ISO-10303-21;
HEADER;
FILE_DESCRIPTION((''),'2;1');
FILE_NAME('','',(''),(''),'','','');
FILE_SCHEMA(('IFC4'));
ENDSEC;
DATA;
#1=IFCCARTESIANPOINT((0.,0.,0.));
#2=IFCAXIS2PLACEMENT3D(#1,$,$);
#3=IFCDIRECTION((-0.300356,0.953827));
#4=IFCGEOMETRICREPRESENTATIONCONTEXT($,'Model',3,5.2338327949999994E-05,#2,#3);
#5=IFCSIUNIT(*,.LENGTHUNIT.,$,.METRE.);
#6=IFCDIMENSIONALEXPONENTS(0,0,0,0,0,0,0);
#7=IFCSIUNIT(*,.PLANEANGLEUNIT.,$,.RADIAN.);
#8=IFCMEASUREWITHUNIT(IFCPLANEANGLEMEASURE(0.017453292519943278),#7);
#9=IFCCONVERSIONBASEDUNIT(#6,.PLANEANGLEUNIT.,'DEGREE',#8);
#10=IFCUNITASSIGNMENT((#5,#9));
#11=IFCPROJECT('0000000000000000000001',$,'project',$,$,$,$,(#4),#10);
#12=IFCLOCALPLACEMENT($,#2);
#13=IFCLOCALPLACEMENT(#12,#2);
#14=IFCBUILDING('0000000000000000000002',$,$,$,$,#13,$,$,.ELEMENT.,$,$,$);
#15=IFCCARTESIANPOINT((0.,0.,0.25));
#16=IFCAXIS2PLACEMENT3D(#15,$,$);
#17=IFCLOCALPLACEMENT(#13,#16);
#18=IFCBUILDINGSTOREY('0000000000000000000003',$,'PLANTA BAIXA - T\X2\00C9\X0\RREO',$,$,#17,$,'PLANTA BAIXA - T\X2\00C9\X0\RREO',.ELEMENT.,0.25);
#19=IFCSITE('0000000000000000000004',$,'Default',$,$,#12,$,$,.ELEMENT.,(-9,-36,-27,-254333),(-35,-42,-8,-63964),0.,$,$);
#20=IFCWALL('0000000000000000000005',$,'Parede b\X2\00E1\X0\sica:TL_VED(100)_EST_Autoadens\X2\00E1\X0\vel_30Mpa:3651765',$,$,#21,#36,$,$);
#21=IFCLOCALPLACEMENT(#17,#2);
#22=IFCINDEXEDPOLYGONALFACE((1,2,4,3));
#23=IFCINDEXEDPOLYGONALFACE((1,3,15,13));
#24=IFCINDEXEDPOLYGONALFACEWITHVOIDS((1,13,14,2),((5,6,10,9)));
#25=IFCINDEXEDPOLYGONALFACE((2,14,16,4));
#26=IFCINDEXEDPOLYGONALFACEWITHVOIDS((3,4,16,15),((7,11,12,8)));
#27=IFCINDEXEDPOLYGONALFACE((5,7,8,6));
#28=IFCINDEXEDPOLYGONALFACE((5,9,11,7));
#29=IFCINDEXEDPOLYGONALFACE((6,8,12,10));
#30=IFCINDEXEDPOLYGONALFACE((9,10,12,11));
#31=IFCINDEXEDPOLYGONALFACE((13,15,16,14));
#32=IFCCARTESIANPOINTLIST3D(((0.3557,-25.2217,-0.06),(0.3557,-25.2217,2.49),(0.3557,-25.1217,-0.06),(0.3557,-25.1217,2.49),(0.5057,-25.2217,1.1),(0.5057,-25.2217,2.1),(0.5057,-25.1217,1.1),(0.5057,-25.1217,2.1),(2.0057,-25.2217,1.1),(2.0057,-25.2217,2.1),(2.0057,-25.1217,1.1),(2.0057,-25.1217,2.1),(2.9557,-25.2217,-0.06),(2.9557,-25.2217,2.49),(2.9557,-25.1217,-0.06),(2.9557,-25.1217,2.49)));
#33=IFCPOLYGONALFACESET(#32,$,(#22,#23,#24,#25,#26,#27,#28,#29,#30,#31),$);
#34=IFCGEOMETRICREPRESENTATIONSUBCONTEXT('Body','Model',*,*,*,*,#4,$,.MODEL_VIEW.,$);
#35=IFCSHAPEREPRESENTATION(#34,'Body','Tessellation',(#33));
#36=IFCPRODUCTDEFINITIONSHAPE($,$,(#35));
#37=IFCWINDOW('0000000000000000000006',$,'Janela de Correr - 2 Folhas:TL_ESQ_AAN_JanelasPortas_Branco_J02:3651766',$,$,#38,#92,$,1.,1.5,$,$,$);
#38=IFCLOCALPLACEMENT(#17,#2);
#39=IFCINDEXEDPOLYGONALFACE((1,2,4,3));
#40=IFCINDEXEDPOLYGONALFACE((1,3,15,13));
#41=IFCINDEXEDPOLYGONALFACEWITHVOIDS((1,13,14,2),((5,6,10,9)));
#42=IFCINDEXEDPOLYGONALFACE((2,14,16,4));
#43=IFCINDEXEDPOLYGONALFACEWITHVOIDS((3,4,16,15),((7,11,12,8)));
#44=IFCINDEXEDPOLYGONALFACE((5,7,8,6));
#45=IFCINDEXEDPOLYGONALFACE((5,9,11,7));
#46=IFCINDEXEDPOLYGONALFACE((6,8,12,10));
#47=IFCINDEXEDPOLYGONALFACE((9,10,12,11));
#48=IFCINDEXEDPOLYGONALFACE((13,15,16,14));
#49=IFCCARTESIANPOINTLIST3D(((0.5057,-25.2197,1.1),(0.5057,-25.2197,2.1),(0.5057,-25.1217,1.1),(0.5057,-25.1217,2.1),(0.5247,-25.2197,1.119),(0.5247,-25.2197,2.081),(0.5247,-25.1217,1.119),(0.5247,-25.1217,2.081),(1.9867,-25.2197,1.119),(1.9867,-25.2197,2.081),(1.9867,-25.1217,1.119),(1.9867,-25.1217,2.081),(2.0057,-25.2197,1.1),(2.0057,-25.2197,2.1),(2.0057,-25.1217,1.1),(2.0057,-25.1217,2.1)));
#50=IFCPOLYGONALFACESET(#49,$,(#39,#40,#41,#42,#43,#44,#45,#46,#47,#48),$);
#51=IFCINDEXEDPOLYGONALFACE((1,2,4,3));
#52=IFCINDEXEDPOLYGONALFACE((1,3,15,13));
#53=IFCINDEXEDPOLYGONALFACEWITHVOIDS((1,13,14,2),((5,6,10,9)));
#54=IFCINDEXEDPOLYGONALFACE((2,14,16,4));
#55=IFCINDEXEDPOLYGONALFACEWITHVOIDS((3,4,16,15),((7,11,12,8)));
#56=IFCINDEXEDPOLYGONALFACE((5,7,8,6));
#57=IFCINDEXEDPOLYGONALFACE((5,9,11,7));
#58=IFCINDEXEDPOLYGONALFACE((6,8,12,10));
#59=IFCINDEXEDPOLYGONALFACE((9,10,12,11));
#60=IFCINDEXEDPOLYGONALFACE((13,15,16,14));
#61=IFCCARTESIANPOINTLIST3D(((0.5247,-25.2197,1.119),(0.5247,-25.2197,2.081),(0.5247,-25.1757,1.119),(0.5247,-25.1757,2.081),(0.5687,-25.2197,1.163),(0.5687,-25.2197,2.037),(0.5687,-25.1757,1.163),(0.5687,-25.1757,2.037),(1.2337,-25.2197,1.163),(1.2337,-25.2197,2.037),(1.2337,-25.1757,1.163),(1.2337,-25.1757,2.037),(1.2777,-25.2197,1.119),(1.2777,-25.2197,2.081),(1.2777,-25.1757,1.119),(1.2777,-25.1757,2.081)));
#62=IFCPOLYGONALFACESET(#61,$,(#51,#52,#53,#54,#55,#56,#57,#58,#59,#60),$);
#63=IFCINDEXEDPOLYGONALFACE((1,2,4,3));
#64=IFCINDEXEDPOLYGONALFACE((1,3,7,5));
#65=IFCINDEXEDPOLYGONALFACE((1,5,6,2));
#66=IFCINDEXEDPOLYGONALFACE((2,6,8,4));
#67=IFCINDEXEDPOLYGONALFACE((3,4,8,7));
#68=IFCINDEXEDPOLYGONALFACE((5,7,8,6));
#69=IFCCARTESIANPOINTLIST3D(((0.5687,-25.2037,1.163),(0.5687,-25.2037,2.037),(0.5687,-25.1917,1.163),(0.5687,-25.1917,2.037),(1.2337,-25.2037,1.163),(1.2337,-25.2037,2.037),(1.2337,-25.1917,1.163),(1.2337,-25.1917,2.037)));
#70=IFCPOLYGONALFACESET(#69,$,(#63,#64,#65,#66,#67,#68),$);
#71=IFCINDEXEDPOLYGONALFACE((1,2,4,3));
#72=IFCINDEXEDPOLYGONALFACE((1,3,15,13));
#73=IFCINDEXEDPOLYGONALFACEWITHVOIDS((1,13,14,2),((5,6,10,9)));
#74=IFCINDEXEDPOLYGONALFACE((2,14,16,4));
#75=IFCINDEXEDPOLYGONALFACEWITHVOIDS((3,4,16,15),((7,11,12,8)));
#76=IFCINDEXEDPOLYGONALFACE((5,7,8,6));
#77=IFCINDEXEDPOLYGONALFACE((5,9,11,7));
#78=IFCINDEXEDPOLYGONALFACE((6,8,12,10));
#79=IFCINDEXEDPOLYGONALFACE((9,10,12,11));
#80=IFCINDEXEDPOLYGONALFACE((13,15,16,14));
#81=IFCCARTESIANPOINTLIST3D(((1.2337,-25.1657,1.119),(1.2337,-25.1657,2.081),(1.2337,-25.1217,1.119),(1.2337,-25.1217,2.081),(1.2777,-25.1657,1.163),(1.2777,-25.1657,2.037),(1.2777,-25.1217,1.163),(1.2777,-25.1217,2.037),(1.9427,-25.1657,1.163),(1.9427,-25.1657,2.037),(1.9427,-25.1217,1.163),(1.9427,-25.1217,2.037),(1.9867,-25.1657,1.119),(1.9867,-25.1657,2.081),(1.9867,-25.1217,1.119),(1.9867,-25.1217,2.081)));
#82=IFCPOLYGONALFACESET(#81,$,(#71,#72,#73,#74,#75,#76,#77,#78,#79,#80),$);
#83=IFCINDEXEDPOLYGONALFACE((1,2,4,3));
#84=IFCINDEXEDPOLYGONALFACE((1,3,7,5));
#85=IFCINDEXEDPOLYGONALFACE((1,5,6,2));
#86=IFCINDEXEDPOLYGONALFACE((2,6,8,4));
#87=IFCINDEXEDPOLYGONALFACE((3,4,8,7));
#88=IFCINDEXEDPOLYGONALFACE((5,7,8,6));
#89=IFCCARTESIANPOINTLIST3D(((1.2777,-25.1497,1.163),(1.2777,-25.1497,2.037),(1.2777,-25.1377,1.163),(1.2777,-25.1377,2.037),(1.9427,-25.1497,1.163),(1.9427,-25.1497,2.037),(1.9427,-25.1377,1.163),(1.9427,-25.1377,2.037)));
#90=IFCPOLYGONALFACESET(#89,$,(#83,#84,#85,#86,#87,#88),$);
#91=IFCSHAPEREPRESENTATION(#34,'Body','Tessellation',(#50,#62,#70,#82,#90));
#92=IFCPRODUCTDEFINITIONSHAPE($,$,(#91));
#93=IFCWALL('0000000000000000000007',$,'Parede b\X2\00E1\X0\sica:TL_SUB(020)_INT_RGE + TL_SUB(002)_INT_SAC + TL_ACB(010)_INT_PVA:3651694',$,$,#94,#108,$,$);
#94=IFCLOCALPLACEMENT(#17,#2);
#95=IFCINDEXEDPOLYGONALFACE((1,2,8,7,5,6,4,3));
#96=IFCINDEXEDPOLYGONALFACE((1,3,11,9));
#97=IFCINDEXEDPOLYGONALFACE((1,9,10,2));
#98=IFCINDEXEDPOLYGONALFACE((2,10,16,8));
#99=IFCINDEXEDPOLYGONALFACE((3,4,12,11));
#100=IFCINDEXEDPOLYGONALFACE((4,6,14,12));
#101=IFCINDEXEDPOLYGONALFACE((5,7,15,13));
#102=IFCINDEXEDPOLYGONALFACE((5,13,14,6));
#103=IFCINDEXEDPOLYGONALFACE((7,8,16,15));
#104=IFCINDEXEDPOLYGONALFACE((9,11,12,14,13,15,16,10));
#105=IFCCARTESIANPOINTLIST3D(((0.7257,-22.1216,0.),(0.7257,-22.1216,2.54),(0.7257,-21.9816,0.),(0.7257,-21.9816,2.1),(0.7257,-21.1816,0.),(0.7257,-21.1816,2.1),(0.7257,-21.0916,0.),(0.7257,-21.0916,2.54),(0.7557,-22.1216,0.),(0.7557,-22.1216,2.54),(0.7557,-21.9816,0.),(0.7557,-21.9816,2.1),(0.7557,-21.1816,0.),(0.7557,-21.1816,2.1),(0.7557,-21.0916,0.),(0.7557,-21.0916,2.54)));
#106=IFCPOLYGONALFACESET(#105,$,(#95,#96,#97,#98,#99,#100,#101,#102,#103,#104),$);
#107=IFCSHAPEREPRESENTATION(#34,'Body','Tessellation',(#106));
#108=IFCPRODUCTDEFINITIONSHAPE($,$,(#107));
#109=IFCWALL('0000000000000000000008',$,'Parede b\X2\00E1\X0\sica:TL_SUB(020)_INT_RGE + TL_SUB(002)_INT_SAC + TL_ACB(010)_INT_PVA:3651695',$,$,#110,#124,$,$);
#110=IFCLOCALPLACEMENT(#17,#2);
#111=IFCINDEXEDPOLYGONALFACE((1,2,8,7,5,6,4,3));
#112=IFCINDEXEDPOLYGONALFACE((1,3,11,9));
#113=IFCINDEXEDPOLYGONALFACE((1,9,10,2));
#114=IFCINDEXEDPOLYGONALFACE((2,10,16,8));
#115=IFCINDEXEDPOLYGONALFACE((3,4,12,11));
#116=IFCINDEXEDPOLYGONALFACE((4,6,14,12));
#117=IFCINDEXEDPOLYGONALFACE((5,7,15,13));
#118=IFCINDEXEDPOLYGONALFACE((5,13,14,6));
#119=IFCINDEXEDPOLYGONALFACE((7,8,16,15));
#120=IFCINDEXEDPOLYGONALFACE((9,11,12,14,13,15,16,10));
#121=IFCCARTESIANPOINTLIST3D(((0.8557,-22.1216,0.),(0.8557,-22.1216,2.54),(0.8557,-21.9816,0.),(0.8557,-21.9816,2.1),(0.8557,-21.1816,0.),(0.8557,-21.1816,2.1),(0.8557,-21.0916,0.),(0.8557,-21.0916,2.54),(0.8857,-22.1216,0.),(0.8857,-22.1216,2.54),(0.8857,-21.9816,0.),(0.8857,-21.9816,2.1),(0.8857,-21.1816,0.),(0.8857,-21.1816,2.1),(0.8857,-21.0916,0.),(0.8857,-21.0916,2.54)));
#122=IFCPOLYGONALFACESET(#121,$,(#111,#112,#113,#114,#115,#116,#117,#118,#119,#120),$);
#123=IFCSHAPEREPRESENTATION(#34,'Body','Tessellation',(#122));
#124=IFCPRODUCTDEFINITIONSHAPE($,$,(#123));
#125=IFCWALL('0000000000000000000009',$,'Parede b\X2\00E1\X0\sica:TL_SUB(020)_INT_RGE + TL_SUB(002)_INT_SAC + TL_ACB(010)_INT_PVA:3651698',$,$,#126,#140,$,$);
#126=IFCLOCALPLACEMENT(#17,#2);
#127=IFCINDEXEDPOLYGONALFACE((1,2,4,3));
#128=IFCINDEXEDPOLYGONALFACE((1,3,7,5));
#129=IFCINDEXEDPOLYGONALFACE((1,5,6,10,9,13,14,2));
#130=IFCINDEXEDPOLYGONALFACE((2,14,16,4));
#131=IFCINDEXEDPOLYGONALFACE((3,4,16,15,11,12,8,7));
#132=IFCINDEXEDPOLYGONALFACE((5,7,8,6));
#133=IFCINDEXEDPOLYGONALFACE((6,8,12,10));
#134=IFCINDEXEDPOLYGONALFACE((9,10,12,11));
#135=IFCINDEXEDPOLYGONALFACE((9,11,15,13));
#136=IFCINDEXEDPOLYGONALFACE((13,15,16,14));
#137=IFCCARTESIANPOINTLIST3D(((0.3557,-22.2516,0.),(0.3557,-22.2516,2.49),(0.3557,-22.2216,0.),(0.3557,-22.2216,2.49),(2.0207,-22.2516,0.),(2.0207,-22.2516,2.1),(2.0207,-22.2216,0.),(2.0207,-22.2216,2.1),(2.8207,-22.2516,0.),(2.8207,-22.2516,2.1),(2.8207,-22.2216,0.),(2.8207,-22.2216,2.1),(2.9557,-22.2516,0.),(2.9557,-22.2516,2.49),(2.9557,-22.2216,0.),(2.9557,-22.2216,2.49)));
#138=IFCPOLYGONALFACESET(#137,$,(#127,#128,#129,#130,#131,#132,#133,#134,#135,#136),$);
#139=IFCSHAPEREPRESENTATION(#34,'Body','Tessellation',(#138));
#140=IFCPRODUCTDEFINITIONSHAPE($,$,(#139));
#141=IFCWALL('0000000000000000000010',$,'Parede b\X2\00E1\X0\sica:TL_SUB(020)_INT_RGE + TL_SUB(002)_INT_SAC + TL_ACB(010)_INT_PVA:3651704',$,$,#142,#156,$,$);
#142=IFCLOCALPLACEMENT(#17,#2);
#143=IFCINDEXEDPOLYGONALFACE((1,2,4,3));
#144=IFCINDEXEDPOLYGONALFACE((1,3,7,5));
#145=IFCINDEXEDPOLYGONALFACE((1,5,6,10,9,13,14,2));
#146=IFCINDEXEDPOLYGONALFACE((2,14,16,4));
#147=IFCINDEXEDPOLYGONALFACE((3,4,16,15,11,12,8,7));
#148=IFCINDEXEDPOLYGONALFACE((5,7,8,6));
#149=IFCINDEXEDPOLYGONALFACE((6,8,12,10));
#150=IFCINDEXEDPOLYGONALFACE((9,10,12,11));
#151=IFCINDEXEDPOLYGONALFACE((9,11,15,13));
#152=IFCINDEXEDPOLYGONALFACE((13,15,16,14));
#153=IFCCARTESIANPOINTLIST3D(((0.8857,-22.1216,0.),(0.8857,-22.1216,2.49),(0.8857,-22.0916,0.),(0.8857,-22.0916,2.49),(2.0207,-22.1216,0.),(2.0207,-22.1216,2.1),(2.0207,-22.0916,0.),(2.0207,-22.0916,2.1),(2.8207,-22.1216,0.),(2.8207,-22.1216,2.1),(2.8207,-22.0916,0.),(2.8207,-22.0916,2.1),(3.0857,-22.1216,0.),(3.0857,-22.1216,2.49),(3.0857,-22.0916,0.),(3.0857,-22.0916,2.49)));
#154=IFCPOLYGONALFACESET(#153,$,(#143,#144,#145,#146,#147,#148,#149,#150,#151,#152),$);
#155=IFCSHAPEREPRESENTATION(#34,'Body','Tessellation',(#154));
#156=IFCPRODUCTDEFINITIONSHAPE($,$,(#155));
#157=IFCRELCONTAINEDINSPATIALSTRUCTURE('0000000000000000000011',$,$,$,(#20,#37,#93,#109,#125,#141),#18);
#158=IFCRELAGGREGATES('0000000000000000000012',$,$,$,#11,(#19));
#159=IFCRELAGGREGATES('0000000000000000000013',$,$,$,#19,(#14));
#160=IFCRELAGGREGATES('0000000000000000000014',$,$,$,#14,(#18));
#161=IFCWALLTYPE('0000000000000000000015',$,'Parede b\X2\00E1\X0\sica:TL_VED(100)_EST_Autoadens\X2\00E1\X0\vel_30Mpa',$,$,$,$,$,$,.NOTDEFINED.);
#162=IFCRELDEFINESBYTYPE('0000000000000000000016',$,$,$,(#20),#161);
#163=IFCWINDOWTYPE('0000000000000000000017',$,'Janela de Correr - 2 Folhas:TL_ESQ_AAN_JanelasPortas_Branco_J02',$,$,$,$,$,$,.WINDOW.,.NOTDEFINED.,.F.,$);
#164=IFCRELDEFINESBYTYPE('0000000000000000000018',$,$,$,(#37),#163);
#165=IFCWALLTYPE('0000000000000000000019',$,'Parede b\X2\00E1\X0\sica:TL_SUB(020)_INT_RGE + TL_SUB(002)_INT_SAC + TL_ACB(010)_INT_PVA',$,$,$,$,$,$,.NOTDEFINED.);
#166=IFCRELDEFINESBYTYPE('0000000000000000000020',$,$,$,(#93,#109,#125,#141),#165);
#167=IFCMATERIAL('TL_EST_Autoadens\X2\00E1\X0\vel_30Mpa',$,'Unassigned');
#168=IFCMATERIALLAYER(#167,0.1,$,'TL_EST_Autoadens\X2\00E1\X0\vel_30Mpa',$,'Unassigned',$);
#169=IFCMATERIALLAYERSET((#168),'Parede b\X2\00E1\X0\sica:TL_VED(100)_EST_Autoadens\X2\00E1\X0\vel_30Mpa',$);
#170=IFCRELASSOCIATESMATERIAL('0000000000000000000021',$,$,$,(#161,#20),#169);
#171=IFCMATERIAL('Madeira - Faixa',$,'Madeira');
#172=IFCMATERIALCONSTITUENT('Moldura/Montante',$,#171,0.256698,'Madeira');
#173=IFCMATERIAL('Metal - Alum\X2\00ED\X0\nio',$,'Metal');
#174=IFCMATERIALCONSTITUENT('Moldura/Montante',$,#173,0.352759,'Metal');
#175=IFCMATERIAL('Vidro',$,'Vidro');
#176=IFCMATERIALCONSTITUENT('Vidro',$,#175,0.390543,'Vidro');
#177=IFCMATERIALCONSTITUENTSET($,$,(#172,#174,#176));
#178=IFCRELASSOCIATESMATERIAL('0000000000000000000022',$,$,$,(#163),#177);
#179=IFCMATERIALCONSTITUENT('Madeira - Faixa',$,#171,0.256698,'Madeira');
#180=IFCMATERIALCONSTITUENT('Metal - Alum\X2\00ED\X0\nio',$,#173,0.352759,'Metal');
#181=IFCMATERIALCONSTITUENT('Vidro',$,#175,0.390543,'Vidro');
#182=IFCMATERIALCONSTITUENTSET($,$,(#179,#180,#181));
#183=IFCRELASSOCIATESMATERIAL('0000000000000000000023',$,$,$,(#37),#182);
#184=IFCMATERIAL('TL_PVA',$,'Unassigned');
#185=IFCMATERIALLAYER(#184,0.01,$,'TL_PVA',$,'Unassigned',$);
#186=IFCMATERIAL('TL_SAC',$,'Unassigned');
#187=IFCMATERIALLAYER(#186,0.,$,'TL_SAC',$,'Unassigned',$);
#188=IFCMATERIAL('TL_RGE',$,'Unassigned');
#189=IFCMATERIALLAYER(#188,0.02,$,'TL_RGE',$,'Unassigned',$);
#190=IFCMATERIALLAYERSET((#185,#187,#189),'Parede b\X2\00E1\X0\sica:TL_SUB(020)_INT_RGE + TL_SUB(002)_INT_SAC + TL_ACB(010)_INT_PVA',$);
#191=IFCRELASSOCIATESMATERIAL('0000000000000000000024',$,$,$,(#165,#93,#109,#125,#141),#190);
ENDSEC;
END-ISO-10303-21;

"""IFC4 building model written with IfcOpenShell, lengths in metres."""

from ifc_helpers import new_model, entity, si_unit, converted_unit, direction, frame, frame_2d, origin, origin_2d_with_axis, place, context, subcontext, project, spatial, polyline, rectangle, outline, extrude, source, transform, mapped, material, layer, layer_set, layer_usage, constituent, constituent_set, type_object, type_shapes, element, fill, save


model = new_model("IFC4")

# Units and contexts
model_context = context("Model", 3, precision=5.2338327949999994e-05, world=origin(), true_north=direction((-0.300356, 0.953827)))
body_context = subcontext(model_context, "Body", "Model", "MODEL_VIEW")
ifc_project = project(units=[si_unit("LENGTHUNIT", "METRE"), converted_unit("PLANEANGLEUNIT", "DEGREE", entity("IfcPlaneAngleMeasure", 0.017453292519943278), si_unit("PLANEANGLEUNIT", "RADIAN"), dimensions=[0, 0, 0, 0, 0, 0, 0])], contexts=[model_context])

# Site, building, storey
site_placement = place(None, origin())
site = spatial("IfcSite", under=ifc_project, at=site_placement, Name="Default", CompositionType="ELEMENT", RefLatitude=(-9, -36, -27, -254333), RefLongitude=(-35, -42, -8, -63964), RefElevation=0.0)
building_placement = place(site_placement, origin())
building = spatial("IfcBuilding", under=site, at=building_placement, CompositionType="ELEMENT")
storey_placement = place(building_placement, frame((0.0, 0.0, 0.25)))
storey = spatial("IfcBuildingStorey", under=building, at=storey_placement, Name="PLANTA BAIXA - TÉRREO", LongName="PLANTA BAIXA - TÉRREO", CompositionType="ELEMENT", Elevation=0.25)

# Shared definitions
ifc_material_1 = material(Name="TL_EST_Autoadensável_30Mpa", Category="Unassigned")
ifc_layer_1 = layer(ifc_material_1, 0.1, Name="TL_EST_Autoadensável_30Mpa", Category="Unassigned")
ifc_layer_set_1 = layer_set([ifc_layer_1], Name="Parede básica:TL_VED(100)_EST_Autoadensável_30Mpa")
wall_type_1 = type_object("IfcWallType", Name="Parede básica:TL_VED(100)_EST_Autoadensável_30Mpa", PredefinedType="NOTDEFINED", material=ifc_layer_set_1)

# Shared definitions
ifc_material_2 = material(Name="Vidro", Category="Vidro")

# Wall, opening, window
ifc_layer_usage_1 = layer_usage(ifc_layer_set_1, "AXIS2", "POSITIVE", -0.05)
wall_1_placement = place(storey_placement, frame((0.3557, -25.1717, -0.06)))
wall_1 = element("IfcWall", 1, at=wall_1_placement, inside=storey, type_object=wall_type_1, material=ifc_layer_usage_1, Name="Parede básica:TL_VED(100)_EST_Autoadensável_30Mpa:3651765", context=body_context, shape_type="SweptSolid", body=[
    extrude(rectangle(XDim=2.6, YDim=0.1, at=frame_2d((1.3, 0.0), x_axis=(-1.0, 0.0))), origin(), (0.0, 0.0, 1.0), 2.55),
])
opening_1_placement = place(wall_1_placement, frame((1.65, 0.05, 1.16)))
opening_1 = element("IfcOpeningElement", 2, at=opening_1_placement, cuts=wall_1, PredefinedType="OPENING", context=body_context, shape_type="SweptSolid", body=[
    extrude(rectangle(XDim=1.0, YDim=1.5, at=frame_2d((0.5, 0.75), x_axis=(-1.0, 0.0))), frame((0.0, 0.0, 0.0), z_axis=(0.0, -1.0, 0.0), x_axis=(0.0, 0.0, 1.0)), (0.0, 0.0, 1.0), 0.1),
])
ifc_material_3 = material(Name="Madeira - Faixa", Category="Madeira")
ifc_constituent_1 = constituent(ifc_material_3, Name="Madeira - Faixa", Category="Madeira", fraction=0.256698)
ifc_material_4 = material(Name="Metal - Alumínio", Category="Metal")
ifc_constituent_2 = constituent(ifc_material_4, Name="Metal - Alumínio", Category="Metal", fraction=0.352759)
ifc_constituent_3 = constituent(ifc_material_2, Name="Vidro", Category="Vidro", fraction=0.390543)
ifc_constituent_set_1 = constituent_set(constituents=[ifc_constituent_1, ifc_constituent_2, ifc_constituent_3])
ifc_constituent_4 = constituent(ifc_material_3, Name="Moldura/Montante", Category="Madeira", fraction=0.256698)
ifc_constituent_5 = constituent(ifc_material_4, Name="Moldura/Montante", Category="Metal", fraction=0.352759)
ifc_constituent_6 = constituent(ifc_material_2, Name="Vidro", Category="Vidro", fraction=0.390543)
ifc_constituent_set_2 = constituent_set(constituents=[ifc_constituent_4, ifc_constituent_5, ifc_constituent_6])
window_type = type_object("IfcWindowType", Name="Janela de Correr - 2 Folhas:TL_ESQ_AAN_JanelasPortas_Branco_J02", ParameterTakesPrecedence=False, PartitioningType="NOTDEFINED", PredefinedType="WINDOW", material=ifc_constituent_set_2)
shared_shape_1 = source(origin(), body_context, "Body", "SweptSolid", [
    extrude(outline(polyline([(-0.75, -0.5), (0.75, -0.5), (0.75, 0.5), (-0.75, 0.5), (-0.75, -0.5)]), holes=[polyline([(-0.731, -0.481), (-0.731, 0.481), (0.731, 0.481), (0.731, -0.481), (-0.731, -0.481)])]), frame((0.75, 0.0, 0.5), z_axis=(0.0, 1.0, 0.0), x_axis=(1.0, 0.0, 0.0)), (0.0, 0.0, 1.0), 0.098),
    extrude(outline(polyline([(-0.3765, -0.481), (0.3765, -0.481), (0.3765, 0.481), (-0.3765, 0.481), (-0.3765, -0.481)]), holes=[polyline([(-0.3325, -0.437), (-0.3325, 0.437), (0.3325, 0.437), (0.3325, -0.437), (-0.3325, -0.437)])]), frame((1.1045, 0.054, 0.5), z_axis=(0.0, 1.0, 0.0), x_axis=(1.0, 0.0, 0.0)), (0.0, 0.0, 1.0), 0.044),
    extrude(rectangle(XDim=0.012, YDim=0.665, at=origin_2d_with_axis()), frame((1.1045, 0.076, 0.063), z_axis=(0.0, 0.0, 1.0), x_axis=(0.0, -1.0, 0.0)), (0.0, 0.0, 1.0), 0.874),
    extrude(outline(polyline([(-0.481, -0.3765), (0.481, -0.3765), (0.481, 0.3765), (-0.481, 0.3765), (-0.481, -0.3765)]), holes=[polyline([(-0.437, -0.3325), (-0.437, 0.3325), (0.437, 0.3325), (0.437, -0.3325), (-0.437, -0.3325)])]), frame((0.3955, 0.0, 0.5), z_axis=(0.0, 1.0, 0.0), x_axis=(0.0, 0.0, -1.0)), (0.0, 0.0, 1.0), 0.044),
    extrude(rectangle(XDim=0.012, YDim=0.665, at=origin_2d_with_axis()), frame((0.3955, 0.022, 0.063), z_axis=(0.0, 0.0, 1.0), x_axis=(0.0, -1.0, 0.0)), (0.0, 0.0, 1.0), 0.874),
])
type_shapes(window_type, [shared_shape_1])
window_placement = place(opening_1_placement, frame((0.0, 0.0, 0.0), z_axis=(0.0, 0.0, 1.0), x_axis=(-1.0, 0.0, 0.0)))
window = element("IfcWindow", 3, at=window_placement, inside=storey, type_object=window_type, material=ifc_constituent_set_1, Name="Janela de Correr - 2 Folhas:TL_ESQ_AAN_JanelasPortas_Branco_J02:3651766", OverallHeight=1.0, OverallWidth=1.5, context=body_context, shape_type="MappedRepresentation", body=[
    mapped(shared_shape_1, transform((0.0, 0.0, 0.0), scale=1.0)),
])
fill(opening_1, window)

# Walls, openings
ifc_material_5 = material(Name="TL_PVA", Category="Unassigned")
ifc_layer_2 = layer(ifc_material_5, 0.01, Name="TL_PVA", Category="Unassigned")
ifc_material_6 = material(Name="TL_SAC", Category="Unassigned")
ifc_layer_3 = layer(ifc_material_6, 0.0, Name="TL_SAC", Category="Unassigned")
ifc_material_7 = material(Name="TL_RGE", Category="Unassigned")
ifc_layer_4 = layer(ifc_material_7, 0.02, Name="TL_RGE", Category="Unassigned")
ifc_layer_set_2 = layer_set([ifc_layer_2, ifc_layer_3, ifc_layer_4], Name="Parede básica:TL_SUB(020)_INT_RGE + TL_SUB(002)_INT_SAC + TL_ACB(010)_INT_PVA")
ifc_layer_usage_2 = layer_usage(ifc_layer_set_2, "AXIS2", "NEGATIVE", 0.015)
wall_type_2 = type_object("IfcWallType", Name="Parede básica:TL_SUB(020)_INT_RGE + TL_SUB(002)_INT_SAC + TL_ACB(010)_INT_PVA", PredefinedType="NOTDEFINED", material=ifc_layer_set_2)
wall_2_placement = place(storey_placement, frame((0.7407, -22.1216, 0.0), z_axis=(0.0, 0.0, 1.0), x_axis=(0.0, 1.0, 0.0)))
wall_2 = element("IfcWall", 4, at=wall_2_placement, inside=storey, type_object=wall_type_2, material=ifc_layer_usage_2, Name="Parede básica:TL_SUB(020)_INT_RGE + TL_SUB(002)_INT_SAC + TL_ACB(010)_INT_PVA:3651694", context=body_context, shape_type="SweptSolid", body=[
    extrude(rectangle(XDim=1.03, YDim=0.03, at=frame_2d((0.515, 0.0), x_axis=(1.0, 0.0))), origin(), (0.0, 0.0, 1.0), 2.54),
])
opening_2_placement = place(wall_2_placement, frame((22.1216, 0.7407, 0.0)))
element("IfcOpeningElement", 5, at=opening_2_placement, cuts=wall_2, PredefinedType="OPENING", context=body_context, shape_type="SweptSolid", body=[
    extrude(rectangle(XDim=2.1, YDim=0.8, at=frame_2d((0.0, 0.0), x_axis=(0.0, 1.0))), frame((-21.5816, -2.3797, 1.05), z_axis=(0.0, 1.0, 0.0), x_axis=(-1.0, 0.0, 0.0)), (0.0, 0.0, 1.0), 3.048),
])
ifc_layer_usage_3 = layer_usage(ifc_layer_set_2, "AXIS2", "NEGATIVE", 0.015)
wall_3_placement = place(storey_placement, frame((0.8707, -21.0916, 0.0), z_axis=(0.0, 0.0, 1.0), x_axis=(0.0, -1.0, 0.0)))
wall_3 = element("IfcWall", 6, at=wall_3_placement, inside=storey, type_object=wall_type_2, material=ifc_layer_usage_3, Name="Parede básica:TL_SUB(020)_INT_RGE + TL_SUB(002)_INT_SAC + TL_ACB(010)_INT_PVA:3651695", context=body_context, shape_type="SweptSolid", body=[
    extrude(rectangle(XDim=1.03, YDim=0.03, at=frame_2d((0.515, 0.0), x_axis=(1.0, 0.0))), origin(), (0.0, 0.0, 1.0), 2.54),
])
opening_3_placement = place(wall_3_placement, frame((-21.0916, -0.8707, 0.0)))
element("IfcOpeningElement", 7, at=opening_3_placement, cuts=wall_3, PredefinedType="OPENING", context=body_context, shape_type="SweptSolid", body=[
    extrude(rectangle(XDim=2.1, YDim=0.8, at=frame_2d((0.0, 0.0), x_axis=(1.0, 0.0))), frame((21.5816, -0.6683, 1.05), z_axis=(0.0, 1.0, 0.0), x_axis=(0.0, 0.0, 1.0)), (0.0, 0.0, 1.0), 3.048),
])
ifc_layer_usage_4 = layer_usage(ifc_layer_set_2, "AXIS2", "NEGATIVE", 0.015)
wall_4_placement = place(storey_placement, frame((2.9557, -22.2366, 0.0), z_axis=(0.0, 0.0, 1.0), x_axis=(-1.0, 0.0, 0.0)))
wall_4 = element("IfcWall", 8, at=wall_4_placement, inside=storey, type_object=wall_type_2, material=ifc_layer_usage_4, Name="Parede básica:TL_SUB(020)_INT_RGE + TL_SUB(002)_INT_SAC + TL_ACB(010)_INT_PVA:3651698", context=body_context, shape_type="SweptSolid", body=[
    extrude(rectangle(XDim=2.6, YDim=0.03, at=frame_2d((1.3, 0.0), x_axis=(1.0, 0.0))), origin(), (0.0, 0.0, 1.0), 2.49),
])
opening_4_placement = place(wall_4_placement, frame((2.9557, -22.2366, 0.0)))
element("IfcOpeningElement", 9, at=opening_4_placement, cuts=wall_4, PredefinedType="OPENING", context=body_context, shape_type="SweptSolid", body=[
    extrude(rectangle(XDim=2.1, YDim=0.8, at=frame_2d((0.0, 0.0), x_axis=(1.0, 0.0))), frame((-2.4207, 20.5976, 1.05), z_axis=(0.0, 1.0, 0.0), x_axis=(0.0, 0.0, 1.0)), (0.0, 0.0, 1.0), 3.048),
])
ifc_layer_usage_5 = layer_usage(ifc_layer_set_2, "AXIS2", "NEGATIVE", 0.015)
wall_5_placement = place(storey_placement, frame((0.8857, -22.1066, 0.0)))
wall_5 = element("IfcWall", 10, at=wall_5_placement, inside=storey, type_object=wall_type_2, material=ifc_layer_usage_5, Name="Parede básica:TL_SUB(020)_INT_RGE + TL_SUB(002)_INT_SAC + TL_ACB(010)_INT_PVA:3651704", context=body_context, shape_type="SweptSolid", body=[
    extrude(rectangle(XDim=2.2, YDim=0.03, at=frame_2d((1.1, 0.0), x_axis=(1.0, 0.0))), origin(), (0.0, 0.0, 1.0), 2.49),
])
opening_5_placement = place(wall_5_placement, frame((-0.8857, 22.1066, 0.0)))
element("IfcOpeningElement", 11, at=opening_5_placement, cuts=wall_5, PredefinedType="OPENING", context=body_context, shape_type="SweptSolid", body=[
    extrude(rectangle(XDim=2.1, YDim=0.8, at=frame_2d((0.0, 0.0), x_axis=(0.0, 1.0))), frame((2.4207, -23.6456, 1.05), z_axis=(0.0, 1.0, 0.0), x_axis=(-1.0, 0.0, 0.0)), (0.0, 0.0, 1.0), 3.048),
])

save(model, "model.ifc")
